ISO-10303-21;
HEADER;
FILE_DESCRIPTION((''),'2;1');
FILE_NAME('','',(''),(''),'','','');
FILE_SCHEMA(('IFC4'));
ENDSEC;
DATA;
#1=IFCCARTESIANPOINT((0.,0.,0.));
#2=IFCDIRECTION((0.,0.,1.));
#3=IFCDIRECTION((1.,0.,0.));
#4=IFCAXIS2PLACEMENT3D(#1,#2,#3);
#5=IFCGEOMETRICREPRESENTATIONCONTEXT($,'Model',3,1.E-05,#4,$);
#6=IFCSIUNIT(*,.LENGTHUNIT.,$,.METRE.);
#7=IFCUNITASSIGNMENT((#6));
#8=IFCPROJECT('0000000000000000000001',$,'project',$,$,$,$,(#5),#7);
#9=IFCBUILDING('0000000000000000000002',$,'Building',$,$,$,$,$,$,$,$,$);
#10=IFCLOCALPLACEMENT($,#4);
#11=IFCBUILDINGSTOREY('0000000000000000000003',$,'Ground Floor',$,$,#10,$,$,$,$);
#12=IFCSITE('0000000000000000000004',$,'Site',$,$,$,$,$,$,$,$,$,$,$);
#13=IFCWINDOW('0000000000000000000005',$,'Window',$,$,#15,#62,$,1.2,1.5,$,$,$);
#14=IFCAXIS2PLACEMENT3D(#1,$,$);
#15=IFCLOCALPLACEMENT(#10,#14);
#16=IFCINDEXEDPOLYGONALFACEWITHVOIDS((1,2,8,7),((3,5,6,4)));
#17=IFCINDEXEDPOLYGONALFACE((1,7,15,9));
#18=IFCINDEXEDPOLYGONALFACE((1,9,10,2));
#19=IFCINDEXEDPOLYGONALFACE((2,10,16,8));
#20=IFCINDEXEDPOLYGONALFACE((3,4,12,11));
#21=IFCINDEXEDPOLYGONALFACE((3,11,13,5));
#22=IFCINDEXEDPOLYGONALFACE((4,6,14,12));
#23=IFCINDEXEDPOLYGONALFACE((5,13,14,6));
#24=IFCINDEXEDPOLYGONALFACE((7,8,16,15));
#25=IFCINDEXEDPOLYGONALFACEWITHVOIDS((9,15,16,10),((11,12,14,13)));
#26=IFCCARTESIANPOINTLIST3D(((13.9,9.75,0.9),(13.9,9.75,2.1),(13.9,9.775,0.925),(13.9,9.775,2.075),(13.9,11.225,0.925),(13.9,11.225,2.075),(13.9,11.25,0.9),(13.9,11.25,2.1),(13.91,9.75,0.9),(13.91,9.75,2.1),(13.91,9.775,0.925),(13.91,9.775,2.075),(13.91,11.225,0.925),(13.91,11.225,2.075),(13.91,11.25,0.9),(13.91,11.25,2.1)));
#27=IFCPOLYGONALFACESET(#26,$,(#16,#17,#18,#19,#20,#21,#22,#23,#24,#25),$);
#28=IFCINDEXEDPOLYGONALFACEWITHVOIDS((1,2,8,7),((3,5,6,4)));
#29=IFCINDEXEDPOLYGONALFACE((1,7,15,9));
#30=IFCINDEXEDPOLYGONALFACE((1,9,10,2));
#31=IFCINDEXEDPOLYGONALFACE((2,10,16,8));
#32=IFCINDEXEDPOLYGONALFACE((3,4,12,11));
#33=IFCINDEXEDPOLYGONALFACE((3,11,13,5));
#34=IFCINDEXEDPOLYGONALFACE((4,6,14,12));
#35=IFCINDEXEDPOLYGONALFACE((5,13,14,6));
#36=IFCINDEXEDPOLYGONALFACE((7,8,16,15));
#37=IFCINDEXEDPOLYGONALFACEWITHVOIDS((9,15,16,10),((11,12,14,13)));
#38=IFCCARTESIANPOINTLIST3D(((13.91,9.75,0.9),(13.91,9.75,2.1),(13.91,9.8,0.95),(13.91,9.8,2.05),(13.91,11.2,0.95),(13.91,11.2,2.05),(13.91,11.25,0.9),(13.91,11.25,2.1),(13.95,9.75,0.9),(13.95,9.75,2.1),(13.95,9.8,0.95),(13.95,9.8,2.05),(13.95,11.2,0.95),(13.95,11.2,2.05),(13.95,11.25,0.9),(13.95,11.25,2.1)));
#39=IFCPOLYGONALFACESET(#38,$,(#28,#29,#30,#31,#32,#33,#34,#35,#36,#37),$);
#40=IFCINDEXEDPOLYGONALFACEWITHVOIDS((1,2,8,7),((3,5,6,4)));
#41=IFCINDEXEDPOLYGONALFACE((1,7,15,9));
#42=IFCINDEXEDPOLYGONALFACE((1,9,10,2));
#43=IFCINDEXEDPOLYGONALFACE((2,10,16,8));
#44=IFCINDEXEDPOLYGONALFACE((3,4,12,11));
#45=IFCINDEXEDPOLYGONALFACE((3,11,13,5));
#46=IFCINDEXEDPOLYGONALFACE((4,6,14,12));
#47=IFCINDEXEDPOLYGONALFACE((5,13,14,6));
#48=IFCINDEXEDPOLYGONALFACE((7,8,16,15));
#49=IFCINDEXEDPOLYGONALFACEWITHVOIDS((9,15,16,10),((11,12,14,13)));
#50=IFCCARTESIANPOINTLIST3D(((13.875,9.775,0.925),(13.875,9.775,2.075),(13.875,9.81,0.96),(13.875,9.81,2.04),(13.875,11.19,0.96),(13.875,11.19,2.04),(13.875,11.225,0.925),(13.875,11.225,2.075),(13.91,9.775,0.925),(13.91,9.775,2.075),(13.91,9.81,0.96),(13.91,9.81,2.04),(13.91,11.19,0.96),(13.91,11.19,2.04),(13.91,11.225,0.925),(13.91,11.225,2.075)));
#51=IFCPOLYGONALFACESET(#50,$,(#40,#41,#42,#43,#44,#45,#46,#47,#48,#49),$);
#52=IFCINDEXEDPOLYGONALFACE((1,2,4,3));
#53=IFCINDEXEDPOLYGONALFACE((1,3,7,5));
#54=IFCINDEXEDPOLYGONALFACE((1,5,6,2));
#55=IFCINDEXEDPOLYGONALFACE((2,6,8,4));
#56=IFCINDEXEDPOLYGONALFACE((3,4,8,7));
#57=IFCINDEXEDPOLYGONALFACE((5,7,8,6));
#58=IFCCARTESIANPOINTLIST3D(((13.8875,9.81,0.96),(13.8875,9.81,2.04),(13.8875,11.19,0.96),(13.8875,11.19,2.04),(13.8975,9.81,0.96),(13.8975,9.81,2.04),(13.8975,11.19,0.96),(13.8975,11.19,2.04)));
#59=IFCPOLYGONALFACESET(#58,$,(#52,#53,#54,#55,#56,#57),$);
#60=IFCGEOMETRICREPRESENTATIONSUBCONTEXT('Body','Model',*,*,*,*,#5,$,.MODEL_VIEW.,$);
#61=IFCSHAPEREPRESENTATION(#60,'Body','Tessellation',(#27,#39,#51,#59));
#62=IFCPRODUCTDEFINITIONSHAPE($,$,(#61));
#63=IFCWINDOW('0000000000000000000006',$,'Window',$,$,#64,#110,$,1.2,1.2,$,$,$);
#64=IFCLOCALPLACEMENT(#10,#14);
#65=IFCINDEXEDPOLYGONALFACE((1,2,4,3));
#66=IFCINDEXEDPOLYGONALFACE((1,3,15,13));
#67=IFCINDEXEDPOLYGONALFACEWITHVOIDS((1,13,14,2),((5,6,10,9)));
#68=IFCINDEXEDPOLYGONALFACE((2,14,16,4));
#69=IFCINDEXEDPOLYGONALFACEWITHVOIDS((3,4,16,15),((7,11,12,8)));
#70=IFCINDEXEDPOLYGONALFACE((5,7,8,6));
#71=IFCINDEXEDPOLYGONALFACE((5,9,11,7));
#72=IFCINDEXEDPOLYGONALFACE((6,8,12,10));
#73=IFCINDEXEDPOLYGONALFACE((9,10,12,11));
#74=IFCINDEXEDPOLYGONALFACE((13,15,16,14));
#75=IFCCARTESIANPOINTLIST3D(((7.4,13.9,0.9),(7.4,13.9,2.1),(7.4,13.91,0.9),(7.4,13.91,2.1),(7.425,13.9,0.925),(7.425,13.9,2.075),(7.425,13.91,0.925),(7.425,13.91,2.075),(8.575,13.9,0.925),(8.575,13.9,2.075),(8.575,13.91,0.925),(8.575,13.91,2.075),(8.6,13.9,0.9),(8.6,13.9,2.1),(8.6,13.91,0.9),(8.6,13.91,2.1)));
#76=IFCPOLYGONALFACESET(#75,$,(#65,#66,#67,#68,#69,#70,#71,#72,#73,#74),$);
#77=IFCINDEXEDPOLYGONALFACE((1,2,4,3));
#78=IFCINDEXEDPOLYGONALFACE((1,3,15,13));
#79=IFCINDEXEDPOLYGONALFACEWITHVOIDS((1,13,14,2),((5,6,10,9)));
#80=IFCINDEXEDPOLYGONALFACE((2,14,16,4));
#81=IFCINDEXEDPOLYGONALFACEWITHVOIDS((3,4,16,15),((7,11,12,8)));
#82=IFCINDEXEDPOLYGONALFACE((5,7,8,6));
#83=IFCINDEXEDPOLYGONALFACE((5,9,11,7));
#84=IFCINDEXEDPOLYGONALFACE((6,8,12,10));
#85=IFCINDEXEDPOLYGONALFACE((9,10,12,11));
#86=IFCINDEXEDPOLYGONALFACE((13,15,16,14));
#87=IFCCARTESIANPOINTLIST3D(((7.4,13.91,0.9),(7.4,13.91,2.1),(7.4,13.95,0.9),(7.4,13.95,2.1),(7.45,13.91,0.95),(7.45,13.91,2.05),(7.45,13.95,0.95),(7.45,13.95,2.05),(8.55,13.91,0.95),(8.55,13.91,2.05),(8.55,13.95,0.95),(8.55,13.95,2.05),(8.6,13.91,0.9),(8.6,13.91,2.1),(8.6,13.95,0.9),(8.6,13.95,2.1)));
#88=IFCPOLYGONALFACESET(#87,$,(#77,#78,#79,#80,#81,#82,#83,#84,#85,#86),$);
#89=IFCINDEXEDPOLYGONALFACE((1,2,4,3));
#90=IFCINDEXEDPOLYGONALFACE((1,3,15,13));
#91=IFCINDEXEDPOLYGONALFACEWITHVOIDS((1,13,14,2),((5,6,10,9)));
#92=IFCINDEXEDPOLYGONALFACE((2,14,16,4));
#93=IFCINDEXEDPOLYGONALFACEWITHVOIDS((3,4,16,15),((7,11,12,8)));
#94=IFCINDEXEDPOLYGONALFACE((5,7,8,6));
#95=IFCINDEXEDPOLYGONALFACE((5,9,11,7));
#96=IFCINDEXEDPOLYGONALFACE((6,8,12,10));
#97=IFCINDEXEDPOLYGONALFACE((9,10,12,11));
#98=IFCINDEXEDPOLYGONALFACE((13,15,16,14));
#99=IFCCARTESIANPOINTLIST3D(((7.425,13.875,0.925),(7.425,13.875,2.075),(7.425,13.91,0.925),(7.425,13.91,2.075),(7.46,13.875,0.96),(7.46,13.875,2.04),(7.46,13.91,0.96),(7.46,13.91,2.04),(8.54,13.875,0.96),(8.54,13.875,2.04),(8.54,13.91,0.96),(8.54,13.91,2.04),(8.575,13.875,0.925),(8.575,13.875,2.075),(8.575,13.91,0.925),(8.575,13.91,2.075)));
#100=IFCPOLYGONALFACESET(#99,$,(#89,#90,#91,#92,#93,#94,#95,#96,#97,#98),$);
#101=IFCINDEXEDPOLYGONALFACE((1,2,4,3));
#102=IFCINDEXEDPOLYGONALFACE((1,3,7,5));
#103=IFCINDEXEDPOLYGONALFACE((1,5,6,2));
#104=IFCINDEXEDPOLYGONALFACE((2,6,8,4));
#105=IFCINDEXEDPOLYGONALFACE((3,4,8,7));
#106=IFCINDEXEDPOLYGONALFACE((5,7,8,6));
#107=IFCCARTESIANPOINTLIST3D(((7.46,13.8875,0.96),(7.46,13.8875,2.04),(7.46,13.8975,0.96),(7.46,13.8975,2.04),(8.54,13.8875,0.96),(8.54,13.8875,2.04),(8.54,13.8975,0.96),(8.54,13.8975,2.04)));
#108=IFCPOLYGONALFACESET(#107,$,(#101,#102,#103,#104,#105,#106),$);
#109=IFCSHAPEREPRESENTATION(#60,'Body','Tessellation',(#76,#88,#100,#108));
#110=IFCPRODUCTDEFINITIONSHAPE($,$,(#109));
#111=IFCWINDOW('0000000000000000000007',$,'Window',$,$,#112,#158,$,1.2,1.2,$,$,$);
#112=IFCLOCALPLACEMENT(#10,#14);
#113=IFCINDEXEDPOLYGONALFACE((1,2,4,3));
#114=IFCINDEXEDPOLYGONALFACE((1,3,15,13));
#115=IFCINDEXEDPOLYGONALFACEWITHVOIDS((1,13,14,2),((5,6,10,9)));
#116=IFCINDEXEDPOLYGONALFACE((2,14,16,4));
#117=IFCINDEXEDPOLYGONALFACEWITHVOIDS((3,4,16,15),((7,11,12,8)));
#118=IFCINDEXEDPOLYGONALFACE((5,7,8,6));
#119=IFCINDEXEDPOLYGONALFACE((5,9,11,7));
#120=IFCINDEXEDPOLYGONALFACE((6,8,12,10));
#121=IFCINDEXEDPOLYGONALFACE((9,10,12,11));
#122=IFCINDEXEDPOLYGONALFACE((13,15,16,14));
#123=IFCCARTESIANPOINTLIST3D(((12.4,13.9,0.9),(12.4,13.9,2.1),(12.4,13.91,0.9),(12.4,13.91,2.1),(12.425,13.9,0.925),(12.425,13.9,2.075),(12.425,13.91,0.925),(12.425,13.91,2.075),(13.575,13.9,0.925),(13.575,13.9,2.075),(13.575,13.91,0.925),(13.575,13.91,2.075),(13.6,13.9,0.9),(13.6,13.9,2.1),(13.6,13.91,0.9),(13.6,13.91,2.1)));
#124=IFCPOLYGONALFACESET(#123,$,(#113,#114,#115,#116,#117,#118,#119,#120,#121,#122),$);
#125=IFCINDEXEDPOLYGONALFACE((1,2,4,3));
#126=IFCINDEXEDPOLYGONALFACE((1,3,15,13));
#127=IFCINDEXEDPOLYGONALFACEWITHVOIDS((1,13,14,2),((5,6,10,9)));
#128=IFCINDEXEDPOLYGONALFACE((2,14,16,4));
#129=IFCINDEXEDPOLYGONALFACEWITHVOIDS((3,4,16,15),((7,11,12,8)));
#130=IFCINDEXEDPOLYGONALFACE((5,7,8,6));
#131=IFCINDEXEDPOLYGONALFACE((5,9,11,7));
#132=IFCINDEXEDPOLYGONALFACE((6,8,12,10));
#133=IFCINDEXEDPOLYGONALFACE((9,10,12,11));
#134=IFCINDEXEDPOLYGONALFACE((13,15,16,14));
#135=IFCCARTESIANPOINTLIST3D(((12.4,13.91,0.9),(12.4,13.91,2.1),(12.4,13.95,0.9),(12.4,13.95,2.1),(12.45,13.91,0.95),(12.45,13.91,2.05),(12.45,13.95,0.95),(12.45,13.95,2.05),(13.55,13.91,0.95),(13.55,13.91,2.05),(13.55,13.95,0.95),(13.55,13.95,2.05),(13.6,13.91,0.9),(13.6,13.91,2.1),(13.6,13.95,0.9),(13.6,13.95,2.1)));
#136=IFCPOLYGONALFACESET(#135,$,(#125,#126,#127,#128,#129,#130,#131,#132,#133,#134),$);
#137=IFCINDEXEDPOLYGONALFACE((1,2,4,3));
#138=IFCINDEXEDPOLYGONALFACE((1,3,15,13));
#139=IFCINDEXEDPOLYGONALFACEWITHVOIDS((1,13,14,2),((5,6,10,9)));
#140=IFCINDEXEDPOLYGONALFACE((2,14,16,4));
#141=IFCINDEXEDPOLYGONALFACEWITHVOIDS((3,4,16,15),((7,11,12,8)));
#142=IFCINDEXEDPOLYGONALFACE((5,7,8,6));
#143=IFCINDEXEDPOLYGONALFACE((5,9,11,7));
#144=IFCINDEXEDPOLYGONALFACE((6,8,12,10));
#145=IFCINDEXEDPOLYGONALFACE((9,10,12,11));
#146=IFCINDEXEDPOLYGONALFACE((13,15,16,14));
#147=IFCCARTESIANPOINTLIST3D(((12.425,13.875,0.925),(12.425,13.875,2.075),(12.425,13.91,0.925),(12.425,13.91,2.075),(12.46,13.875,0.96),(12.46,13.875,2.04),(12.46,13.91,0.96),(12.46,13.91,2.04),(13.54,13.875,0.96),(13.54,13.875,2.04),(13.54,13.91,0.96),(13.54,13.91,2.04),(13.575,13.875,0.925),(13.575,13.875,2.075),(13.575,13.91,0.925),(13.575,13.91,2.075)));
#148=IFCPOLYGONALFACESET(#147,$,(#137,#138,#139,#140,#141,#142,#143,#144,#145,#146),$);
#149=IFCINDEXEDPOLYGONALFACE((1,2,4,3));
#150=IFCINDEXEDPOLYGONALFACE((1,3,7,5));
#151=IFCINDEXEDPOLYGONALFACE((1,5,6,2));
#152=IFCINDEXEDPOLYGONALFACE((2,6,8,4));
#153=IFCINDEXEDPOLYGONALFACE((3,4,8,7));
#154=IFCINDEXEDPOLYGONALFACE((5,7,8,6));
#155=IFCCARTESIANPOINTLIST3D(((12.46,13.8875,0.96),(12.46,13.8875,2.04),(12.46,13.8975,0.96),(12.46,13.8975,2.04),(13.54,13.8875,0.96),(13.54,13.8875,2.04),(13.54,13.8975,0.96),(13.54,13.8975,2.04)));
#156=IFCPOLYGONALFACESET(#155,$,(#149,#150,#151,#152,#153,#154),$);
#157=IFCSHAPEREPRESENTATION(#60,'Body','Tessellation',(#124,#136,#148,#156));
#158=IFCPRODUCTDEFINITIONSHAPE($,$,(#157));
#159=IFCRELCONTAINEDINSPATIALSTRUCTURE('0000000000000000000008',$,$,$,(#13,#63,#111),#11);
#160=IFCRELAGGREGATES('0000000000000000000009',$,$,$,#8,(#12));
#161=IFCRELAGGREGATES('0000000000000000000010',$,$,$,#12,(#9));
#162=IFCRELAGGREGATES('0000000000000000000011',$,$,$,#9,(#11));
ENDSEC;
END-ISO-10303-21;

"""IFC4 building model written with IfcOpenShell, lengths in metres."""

from ifc_helpers import new_model, si_unit, frame, origin_with_axes, place, context, subcontext, project, spatial, line, indexed_curve, outline, extrude, element, save


model = new_model("IFC4")

# Units and contexts
model_context = context("Model", 3, precision=1e-05, world=origin_with_axes())
body_context = subcontext(model_context, "Body", "Model", "MODEL_VIEW")
ifc_project = project(units=[si_unit("LENGTHUNIT", "METRE")], contexts=[model_context])

# Site, building, storey
site = spatial("IfcSite", under=ifc_project, Name="Site")
building = spatial("IfcBuilding", under=site, Name="Building")
storey_placement = place(None, origin_with_axes())
storey = spatial("IfcBuildingStorey", under=building, at=storey_placement, Name="Ground Floor")

# Windows
window_placement = place(storey_placement, frame((14.0, 9.75, 0.9), z_axis=(0.0, 0.0, 1.0), x_axis=(0.0, 1.0, 0.0)))
element("IfcWindow", 1, at=window_placement, inside=storey, Name="Window", OverallHeight=1.2, OverallWidth=1.5, context=body_context, shape_type="SweptSolid", body=[
    extrude(outline(indexed_curve([(0.0, 0.0), (1.5, 0.0), (1.5, 1.2), (0.0, 1.2)], segments=[line(1, 2, 3, 4, 1)]), holes=[indexed_curve([(0.025, 0.025), (1.475, 0.025), (1.475, 1.175), (0.025, 1.175)], segments=[line(1, 2, 3, 4, 1)])]), frame((0.0, 0.09, 0.0), z_axis=(0.0, -1.0, 0.0), x_axis=(1.0, 0.0, 0.0)), (0.0, 0.0, -1.0), 0.01),
    extrude(outline(indexed_curve([(0.0, 0.0), (1.5, 0.0), (1.5, 1.2), (0.0, 1.2)], segments=[line(1, 2, 3, 4, 1)]), holes=[indexed_curve([(0.05, 0.05), (1.45, 0.05), (1.45, 1.15), (0.05, 1.15)], segments=[line(1, 2, 3, 4, 1)])]), frame((0.0, 0.05, 0.0), z_axis=(0.0, -1.0, 0.0), x_axis=(1.0, 0.0, 0.0)), (0.0, 0.0, -1.0), 0.04),
    extrude(outline(indexed_curve([(0.0, 0.0), (1.45, 0.0), (1.45, 1.15), (0.0, 1.15)], segments=[line(1, 2, 3, 4, 1)]), holes=[indexed_curve([(0.035, 0.035), (1.415, 0.035), (1.415, 1.115), (0.035, 1.115)], segments=[line(1, 2, 3, 4, 1)])]), frame((0.025, 0.09, 0.025), z_axis=(0.0, -1.0, 0.0), x_axis=(1.0, 0.0, 0.0)), (0.0, 0.0, -1.0), 0.035),
    extrude(outline(indexed_curve([(0.035, 0.035), (1.415, 0.035), (1.415, 1.115), (0.035, 1.115)], segments=[line(1, 2, 3, 4, 1)])), frame((0.025, 0.1025, 0.025), z_axis=(0.0, -1.0, 0.0), x_axis=(1.0, 0.0, 0.0)), (0.0, 0.0, -1.0), 0.01),
])
for number, where, z_axis, x_axis, name in (
    (2, (8.6, 14.0, 0.9), (0.0, 0.0, 1.0), (-1.0, 0.0, 0.0), "Window"),
    (3, (13.6, 14.0, 0.9), (0.0, 0.0, 1.0), (-1.0, 0.0, 0.0), "Window"),
):
    element("IfcWindow", number, at=place(storey_placement, frame(where, z_axis=z_axis, x_axis=x_axis)), inside=storey, Name=name, OverallHeight=1.2, OverallWidth=1.2, context=body_context, shape_type="SweptSolid", body=[
        extrude(outline(indexed_curve([(0.0, 0.0), (1.2, 0.0), (1.2, 1.2), (0.0, 1.2)], segments=[line(1, 2, 3, 4, 1)]), holes=[indexed_curve([(0.025, 0.025), (1.175, 0.025), (1.175, 1.175), (0.025, 1.175)], segments=[line(1, 2, 3, 4, 1)])]), frame((0.0, 0.09, 0.0), z_axis=(0.0, -1.0, 0.0), x_axis=(1.0, 0.0, 0.0)), (0.0, 0.0, -1.0), 0.01),
        extrude(outline(indexed_curve([(0.0, 0.0), (1.2, 0.0), (1.2, 1.2), (0.0, 1.2)], segments=[line(1, 2, 3, 4, 1)]), holes=[indexed_curve([(0.05, 0.05), (1.15, 0.05), (1.15, 1.15), (0.05, 1.15)], segments=[line(1, 2, 3, 4, 1)])]), frame((0.0, 0.05, 0.0), z_axis=(0.0, -1.0, 0.0), x_axis=(1.0, 0.0, 0.0)), (0.0, 0.0, -1.0), 0.04),
        extrude(outline(indexed_curve([(0.0, 0.0), (1.15, 0.0), (1.15, 1.15), (0.0, 1.15)], segments=[line(1, 2, 3, 4, 1)]), holes=[indexed_curve([(0.035, 0.035), (1.115, 0.035), (1.115, 1.115), (0.035, 1.115)], segments=[line(1, 2, 3, 4, 1)])]), frame((0.025, 0.09, 0.025), z_axis=(0.0, -1.0, 0.0), x_axis=(1.0, 0.0, 0.0)), (0.0, 0.0, -1.0), 0.035),
        extrude(outline(indexed_curve([(0.035, 0.035), (1.115, 0.035), (1.115, 1.115), (0.035, 1.115)], segments=[line(1, 2, 3, 4, 1)])), frame((0.025, 0.1025, 0.025), z_axis=(0.0, -1.0, 0.0), x_axis=(1.0, 0.0, 0.0)), (0.0, 0.0, -1.0), 0.01),
    ])

save(model, "model.ifc")
